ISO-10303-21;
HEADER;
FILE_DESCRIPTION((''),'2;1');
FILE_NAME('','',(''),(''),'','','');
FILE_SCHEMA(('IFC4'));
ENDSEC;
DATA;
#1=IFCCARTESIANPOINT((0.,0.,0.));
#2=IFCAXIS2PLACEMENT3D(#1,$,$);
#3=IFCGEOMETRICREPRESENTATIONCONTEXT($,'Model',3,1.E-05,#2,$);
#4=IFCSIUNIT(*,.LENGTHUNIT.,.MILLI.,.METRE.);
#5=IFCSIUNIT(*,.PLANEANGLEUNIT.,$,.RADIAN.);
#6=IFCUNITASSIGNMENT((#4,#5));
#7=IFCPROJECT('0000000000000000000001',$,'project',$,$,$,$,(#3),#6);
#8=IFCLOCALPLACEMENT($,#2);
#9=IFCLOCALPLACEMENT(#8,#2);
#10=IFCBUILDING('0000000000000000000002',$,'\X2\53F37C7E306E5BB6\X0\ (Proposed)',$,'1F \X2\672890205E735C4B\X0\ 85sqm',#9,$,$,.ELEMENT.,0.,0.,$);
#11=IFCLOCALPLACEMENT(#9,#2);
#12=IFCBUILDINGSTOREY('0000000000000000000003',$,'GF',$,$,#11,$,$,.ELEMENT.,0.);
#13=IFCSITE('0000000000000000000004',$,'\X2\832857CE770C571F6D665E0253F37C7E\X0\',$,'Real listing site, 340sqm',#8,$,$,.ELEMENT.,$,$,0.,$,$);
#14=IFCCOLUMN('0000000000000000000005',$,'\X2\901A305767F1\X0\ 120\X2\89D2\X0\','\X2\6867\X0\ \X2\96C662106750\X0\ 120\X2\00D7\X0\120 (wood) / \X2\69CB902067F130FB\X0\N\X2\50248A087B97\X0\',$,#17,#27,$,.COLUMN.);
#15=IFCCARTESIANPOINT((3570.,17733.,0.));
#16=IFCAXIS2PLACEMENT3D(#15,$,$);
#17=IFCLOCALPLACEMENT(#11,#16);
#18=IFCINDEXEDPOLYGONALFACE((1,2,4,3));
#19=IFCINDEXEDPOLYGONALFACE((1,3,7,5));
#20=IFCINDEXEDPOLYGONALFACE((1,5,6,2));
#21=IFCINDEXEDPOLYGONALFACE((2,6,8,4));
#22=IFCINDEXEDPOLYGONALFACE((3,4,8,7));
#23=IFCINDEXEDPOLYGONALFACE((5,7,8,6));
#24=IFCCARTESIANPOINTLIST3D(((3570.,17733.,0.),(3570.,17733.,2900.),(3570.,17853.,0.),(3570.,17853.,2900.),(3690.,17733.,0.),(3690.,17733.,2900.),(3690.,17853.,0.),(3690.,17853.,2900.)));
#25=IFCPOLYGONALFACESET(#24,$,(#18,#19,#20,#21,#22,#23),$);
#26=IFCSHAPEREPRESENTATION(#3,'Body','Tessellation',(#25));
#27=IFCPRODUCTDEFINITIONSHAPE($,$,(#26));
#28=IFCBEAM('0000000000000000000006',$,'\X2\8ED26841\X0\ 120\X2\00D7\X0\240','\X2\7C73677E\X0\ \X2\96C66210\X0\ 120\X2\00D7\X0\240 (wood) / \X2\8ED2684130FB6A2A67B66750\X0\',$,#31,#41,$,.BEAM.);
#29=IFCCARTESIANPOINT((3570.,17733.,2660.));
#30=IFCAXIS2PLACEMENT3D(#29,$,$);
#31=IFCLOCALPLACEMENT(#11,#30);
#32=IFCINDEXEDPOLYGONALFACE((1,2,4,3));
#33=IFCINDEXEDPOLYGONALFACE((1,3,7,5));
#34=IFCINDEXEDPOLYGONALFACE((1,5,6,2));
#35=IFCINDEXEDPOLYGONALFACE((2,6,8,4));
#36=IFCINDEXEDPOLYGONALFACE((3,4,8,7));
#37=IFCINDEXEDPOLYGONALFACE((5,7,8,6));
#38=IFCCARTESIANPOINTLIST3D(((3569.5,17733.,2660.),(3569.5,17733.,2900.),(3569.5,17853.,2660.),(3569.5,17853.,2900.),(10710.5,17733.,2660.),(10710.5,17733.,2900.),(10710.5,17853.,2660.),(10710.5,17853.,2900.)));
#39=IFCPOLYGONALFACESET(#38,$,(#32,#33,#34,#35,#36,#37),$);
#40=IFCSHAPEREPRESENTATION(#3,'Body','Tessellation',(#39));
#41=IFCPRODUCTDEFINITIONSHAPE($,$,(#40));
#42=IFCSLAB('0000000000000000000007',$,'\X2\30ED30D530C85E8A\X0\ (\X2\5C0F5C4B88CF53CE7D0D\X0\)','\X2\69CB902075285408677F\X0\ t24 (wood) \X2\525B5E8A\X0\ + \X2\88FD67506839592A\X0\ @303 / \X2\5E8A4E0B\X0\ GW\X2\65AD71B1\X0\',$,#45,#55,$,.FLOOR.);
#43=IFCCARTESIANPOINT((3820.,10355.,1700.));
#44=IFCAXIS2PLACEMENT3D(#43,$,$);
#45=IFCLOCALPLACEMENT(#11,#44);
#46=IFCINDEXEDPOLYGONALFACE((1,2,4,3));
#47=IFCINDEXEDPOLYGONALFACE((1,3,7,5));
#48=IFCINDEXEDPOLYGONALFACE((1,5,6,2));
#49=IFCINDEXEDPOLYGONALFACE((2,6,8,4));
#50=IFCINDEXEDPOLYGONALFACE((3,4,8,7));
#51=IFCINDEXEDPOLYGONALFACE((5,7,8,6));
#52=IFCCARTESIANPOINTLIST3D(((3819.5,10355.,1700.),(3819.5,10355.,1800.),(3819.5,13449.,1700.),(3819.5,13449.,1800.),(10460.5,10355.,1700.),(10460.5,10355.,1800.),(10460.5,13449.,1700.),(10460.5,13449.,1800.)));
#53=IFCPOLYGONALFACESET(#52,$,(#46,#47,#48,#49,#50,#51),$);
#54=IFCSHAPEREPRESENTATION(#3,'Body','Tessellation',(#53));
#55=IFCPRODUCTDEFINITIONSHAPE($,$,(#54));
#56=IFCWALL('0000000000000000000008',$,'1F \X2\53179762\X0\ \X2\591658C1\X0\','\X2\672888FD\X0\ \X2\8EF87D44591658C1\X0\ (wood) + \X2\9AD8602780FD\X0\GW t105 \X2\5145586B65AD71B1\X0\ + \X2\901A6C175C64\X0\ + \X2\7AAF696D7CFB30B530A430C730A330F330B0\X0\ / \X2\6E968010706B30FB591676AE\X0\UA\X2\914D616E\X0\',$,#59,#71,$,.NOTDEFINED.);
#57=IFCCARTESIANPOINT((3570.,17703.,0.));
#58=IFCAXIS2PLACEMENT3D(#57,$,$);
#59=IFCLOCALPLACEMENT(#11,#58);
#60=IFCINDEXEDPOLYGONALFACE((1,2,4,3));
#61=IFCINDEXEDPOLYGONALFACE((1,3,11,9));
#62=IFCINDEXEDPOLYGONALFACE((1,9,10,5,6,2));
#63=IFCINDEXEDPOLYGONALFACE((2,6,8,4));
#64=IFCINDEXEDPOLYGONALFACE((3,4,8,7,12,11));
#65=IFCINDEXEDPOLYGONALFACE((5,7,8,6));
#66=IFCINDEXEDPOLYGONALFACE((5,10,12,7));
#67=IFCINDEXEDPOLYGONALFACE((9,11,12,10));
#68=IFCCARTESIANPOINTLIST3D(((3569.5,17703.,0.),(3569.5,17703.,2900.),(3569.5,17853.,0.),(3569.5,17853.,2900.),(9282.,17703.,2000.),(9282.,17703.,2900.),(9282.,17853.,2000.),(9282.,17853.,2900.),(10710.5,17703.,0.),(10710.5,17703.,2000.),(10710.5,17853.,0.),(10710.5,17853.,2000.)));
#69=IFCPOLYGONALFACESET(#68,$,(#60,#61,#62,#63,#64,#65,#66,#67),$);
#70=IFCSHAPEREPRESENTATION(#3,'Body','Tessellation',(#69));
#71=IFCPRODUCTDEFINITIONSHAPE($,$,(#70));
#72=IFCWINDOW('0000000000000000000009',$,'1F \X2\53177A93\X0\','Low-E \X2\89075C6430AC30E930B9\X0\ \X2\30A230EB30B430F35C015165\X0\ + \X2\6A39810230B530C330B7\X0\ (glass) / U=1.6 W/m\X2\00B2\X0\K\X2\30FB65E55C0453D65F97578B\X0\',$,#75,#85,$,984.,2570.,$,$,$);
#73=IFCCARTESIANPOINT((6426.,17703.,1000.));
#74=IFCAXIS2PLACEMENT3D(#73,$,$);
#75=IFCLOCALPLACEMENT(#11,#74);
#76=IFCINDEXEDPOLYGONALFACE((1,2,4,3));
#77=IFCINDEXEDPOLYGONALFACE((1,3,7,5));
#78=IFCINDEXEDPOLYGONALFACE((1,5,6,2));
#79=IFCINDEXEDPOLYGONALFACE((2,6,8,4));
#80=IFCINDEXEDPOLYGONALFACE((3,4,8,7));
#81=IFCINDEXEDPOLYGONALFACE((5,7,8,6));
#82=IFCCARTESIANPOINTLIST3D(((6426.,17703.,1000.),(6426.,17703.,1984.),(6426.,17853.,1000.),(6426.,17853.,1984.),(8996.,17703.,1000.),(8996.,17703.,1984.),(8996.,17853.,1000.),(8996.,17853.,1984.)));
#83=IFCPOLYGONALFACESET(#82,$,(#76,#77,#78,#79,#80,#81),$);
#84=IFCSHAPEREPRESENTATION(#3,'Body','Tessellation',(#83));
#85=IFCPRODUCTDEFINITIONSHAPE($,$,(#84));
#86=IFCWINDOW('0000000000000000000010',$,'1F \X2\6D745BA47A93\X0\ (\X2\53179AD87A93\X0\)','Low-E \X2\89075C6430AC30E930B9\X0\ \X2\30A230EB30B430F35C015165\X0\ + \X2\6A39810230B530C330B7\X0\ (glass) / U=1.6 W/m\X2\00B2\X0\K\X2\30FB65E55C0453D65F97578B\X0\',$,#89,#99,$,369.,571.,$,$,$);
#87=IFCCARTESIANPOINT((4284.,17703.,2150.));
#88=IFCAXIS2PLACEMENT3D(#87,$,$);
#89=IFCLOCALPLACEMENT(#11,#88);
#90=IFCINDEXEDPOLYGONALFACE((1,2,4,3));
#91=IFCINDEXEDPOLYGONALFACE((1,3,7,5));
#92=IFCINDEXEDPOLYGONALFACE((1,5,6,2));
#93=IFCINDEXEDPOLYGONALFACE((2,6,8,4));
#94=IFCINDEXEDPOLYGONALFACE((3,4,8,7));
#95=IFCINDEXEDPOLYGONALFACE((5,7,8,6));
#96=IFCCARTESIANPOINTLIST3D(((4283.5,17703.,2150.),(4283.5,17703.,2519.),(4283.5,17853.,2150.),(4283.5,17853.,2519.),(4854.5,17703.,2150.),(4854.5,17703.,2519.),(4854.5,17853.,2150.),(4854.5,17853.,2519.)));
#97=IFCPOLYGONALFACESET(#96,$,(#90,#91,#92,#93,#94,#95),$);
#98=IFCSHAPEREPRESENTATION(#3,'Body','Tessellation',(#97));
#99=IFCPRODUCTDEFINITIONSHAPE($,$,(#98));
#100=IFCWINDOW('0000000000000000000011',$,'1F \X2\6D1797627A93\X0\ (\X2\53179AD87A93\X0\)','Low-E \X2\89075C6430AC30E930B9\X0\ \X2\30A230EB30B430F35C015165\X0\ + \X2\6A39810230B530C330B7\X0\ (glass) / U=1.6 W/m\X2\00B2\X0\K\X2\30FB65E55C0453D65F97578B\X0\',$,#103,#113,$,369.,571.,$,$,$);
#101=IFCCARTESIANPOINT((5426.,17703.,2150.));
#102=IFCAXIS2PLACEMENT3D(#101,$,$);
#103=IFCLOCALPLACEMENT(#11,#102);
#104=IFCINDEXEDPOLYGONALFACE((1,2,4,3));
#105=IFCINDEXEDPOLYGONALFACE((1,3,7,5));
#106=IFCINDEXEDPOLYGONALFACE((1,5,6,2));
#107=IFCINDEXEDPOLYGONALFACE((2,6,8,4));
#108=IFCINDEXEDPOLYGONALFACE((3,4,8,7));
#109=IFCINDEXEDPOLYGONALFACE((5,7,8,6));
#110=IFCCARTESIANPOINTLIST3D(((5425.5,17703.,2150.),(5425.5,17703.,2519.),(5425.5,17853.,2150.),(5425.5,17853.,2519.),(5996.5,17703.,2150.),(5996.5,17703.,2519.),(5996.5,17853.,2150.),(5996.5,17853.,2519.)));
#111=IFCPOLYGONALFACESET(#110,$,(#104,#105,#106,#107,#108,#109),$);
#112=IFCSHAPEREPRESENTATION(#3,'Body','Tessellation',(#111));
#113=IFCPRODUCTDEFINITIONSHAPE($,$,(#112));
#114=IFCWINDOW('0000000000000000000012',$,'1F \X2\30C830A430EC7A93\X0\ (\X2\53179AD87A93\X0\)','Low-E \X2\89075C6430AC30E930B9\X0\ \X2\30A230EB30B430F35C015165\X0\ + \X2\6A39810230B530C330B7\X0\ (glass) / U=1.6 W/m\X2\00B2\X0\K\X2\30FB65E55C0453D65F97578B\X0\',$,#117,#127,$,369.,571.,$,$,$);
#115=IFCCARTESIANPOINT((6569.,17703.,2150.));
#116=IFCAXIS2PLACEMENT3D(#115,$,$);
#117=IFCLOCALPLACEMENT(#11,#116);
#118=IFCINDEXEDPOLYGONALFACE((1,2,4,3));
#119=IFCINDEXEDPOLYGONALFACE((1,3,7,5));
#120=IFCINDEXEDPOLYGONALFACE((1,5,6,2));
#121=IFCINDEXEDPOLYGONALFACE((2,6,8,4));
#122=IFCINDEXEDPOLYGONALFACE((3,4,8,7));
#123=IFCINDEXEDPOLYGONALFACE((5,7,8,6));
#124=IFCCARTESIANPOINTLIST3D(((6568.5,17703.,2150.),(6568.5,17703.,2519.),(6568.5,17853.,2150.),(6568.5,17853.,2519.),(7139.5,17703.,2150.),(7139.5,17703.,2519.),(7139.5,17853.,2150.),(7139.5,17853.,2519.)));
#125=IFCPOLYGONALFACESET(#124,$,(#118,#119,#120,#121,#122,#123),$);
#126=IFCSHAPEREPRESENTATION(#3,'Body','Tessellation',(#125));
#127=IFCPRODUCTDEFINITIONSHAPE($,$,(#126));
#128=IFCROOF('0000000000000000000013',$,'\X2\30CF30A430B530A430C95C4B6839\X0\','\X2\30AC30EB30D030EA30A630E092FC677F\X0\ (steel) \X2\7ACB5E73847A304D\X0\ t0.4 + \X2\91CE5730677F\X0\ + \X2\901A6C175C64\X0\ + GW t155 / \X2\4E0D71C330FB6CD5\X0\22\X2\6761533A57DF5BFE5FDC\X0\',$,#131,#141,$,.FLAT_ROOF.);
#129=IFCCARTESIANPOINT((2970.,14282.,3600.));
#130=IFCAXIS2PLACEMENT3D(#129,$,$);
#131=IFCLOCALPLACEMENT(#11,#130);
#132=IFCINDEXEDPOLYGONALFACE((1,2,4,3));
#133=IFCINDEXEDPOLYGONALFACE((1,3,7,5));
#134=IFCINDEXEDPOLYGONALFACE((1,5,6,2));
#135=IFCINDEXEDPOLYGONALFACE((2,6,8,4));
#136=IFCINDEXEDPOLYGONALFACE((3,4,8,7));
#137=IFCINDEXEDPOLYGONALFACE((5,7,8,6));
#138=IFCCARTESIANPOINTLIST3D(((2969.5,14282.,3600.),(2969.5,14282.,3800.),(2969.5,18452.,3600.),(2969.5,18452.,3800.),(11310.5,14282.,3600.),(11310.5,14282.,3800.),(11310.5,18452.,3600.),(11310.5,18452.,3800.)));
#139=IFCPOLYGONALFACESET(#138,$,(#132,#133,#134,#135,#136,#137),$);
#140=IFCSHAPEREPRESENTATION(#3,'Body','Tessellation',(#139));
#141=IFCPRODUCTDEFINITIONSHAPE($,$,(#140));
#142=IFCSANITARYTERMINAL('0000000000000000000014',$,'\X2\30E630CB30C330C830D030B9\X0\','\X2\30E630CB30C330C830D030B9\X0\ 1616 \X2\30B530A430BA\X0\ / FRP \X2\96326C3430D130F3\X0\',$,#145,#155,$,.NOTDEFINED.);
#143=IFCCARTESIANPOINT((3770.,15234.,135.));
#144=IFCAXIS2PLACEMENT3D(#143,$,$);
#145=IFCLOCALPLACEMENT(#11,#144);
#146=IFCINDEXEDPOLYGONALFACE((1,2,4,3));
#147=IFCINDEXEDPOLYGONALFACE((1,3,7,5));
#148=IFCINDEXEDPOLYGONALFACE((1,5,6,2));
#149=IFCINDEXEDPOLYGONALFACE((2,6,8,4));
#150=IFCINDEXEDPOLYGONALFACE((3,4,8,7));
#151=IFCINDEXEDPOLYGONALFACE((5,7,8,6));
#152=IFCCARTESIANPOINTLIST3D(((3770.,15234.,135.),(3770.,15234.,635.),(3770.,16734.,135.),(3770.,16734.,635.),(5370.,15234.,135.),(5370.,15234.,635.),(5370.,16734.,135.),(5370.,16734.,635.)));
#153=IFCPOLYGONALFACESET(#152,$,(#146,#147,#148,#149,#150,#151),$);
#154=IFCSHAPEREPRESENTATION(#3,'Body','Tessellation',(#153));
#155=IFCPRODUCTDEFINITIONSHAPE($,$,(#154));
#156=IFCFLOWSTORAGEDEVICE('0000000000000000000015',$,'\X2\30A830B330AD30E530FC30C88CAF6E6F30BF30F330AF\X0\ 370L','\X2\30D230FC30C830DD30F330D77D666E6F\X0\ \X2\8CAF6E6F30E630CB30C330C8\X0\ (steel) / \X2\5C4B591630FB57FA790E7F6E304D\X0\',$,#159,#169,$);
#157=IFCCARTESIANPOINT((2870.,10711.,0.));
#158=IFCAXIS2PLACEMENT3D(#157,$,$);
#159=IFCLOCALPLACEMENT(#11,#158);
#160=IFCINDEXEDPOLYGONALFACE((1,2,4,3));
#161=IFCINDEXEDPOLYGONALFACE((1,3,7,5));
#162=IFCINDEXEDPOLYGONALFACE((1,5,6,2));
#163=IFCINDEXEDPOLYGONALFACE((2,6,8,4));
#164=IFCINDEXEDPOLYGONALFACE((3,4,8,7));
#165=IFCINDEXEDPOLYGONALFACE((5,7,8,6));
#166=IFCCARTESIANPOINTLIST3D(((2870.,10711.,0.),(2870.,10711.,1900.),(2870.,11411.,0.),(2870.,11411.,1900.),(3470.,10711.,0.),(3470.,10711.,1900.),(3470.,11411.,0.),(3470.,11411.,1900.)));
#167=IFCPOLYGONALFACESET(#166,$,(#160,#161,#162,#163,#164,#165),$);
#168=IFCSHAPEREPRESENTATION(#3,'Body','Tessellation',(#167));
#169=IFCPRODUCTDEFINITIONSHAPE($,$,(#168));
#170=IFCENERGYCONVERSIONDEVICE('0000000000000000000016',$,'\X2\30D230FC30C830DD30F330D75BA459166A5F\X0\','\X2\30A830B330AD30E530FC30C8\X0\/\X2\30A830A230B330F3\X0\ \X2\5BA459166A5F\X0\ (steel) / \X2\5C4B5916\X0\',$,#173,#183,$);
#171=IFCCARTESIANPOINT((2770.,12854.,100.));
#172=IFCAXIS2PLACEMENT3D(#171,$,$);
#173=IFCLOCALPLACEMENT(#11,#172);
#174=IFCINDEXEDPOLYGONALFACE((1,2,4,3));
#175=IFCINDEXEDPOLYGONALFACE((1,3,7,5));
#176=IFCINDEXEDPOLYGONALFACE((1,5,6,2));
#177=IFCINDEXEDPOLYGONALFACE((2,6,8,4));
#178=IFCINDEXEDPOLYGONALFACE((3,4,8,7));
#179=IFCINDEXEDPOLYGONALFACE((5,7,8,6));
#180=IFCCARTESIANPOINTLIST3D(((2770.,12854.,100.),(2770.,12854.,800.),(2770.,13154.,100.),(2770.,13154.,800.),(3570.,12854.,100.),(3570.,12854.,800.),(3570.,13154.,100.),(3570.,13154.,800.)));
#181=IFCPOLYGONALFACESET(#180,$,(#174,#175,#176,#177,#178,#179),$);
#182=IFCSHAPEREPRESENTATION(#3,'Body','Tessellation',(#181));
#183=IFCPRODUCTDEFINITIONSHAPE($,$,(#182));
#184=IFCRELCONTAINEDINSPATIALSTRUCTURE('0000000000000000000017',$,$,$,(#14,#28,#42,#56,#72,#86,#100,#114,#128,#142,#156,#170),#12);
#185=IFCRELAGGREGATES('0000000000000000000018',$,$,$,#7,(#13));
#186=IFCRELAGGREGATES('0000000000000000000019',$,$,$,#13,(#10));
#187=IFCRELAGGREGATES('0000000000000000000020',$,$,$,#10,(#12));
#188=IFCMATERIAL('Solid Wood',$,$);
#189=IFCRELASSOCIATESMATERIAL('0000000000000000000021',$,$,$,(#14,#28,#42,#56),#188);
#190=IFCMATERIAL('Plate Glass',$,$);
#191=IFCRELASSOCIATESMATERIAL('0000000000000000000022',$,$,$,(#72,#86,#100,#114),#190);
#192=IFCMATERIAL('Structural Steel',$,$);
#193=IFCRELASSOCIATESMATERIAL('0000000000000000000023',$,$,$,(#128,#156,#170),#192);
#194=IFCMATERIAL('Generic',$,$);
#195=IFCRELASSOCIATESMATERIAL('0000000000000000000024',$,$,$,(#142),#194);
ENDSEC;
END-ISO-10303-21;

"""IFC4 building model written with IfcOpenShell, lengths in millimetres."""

from ifc_helpers import new_model, si_unit, frame, frame_2d, origin, place, context, project, spatial, rectangle, extrude, material, element, fill, save


model = new_model("IFC4")

# Units and contexts
model_context = context("Model", 3, precision=1e-05, world=origin())
ifc_project = project(units=[si_unit("LENGTHUNIT", "METRE", prefix="MILLI"), si_unit("PLANEANGLEUNIT", "RADIAN")], contexts=[model_context])

# Site, building, storey
site_placement = place(None, origin())
site = spatial("IfcSite", under=ifc_project, at=site_placement, Name="茨城県土浦市右籾", ObjectType="Real listing site, 340sqm", CompositionType="ELEMENT", RefElevation=0.0)
building_placement = place(site_placement, origin())
building = spatial("IfcBuilding", under=site, at=building_placement, Name="右籾の家 (Proposed)", ObjectType="1F 木造平屋 85sqm", CompositionType="ELEMENT", ElevationOfRefHeight=0.0, ElevationOfTerrain=0.0)
storey_placement = place(building_placement, origin())
storey = spatial("IfcBuildingStorey", under=building, at=storey_placement, Name="GF", CompositionType="ELEMENT", Elevation=0.0)

# Column
ifc_material_1 = material(Name="Solid Wood")
column_1_placement = place(storey_placement, frame((3570.0, 17733.0, 0.0)))
element("IfcColumn", 1, at=column_1_placement, inside=storey, material=ifc_material_1, Name="通し柱 120角", Description="桧 集成材 120×120 (wood) / 構造柱・N値計算", PredefinedType="COLUMN", context=model_context, shape_type="SweptSolid", body=[
    extrude(rectangle(XDim=120.0, YDim=120.0, at=frame_2d((60.0, 60.0))), frame((3570.0, 17733.0, 0.0)), (0.0, 0.0, 1.0), 2900.0),
])

# Beam
beam_1_placement = place(storey_placement, frame((3570.0, 17733.0, 2660.0)))
element("IfcBeam", 2, at=beam_1_placement, inside=storey, material=ifc_material_1, Name="軒桁 120×240", Description="米松 集成 120×240 (wood) / 軒桁・横架材", PredefinedType="BEAM", context=model_context, shape_type="SweptSolid", body=[
    extrude(rectangle(XDim=7141.0, YDim=120.0, at=frame_2d((3570.0, 60.0))), frame((3570.0, 17733.0, 2660.0)), (0.0, 0.0, 1.0), 240.0),
])

# Slab
slab_placement = place(storey_placement, frame((3820.0, 10355.0, 1700.0)))
element("IfcSlab", 3, at=slab_placement, inside=storey, material=ifc_material_1, Name="ロフト床 (小屋裏収納)", Description="構造用合板 t24 (wood) 剛床 + 製材根太 @303 / 床下 GW断熱", PredefinedType="FLOOR", context=model_context, shape_type="SweptSolid", body=[
    extrude(rectangle(XDim=6641.0, YDim=3094.0, at=frame_2d((3320.0, 1547.0))), frame((3820.0, 10355.0, 1700.0)), (0.0, 0.0, 1.0), 100.0),
])

# Wall, openings, windows
wall_1_placement = place(storey_placement, frame((3570.0, 17703.0, 0.0)))
wall_1 = element("IfcWall", 4, at=wall_1_placement, inside=storey, material=ifc_material_1, Name="1F 北面 外壁", Description="木製 軸組外壁 (wood) + 高性能GW t105 充填断熱 + 通気層 + 窯業系サイディング / 準耐火・外皮UA配慮", PredefinedType="NOTDEFINED", context=model_context, shape_type="SweptSolid", body=[
    extrude(rectangle(XDim=7141.0, YDim=150.0, at=frame_2d((3570.0, 75.0))), frame((3570.0, 17703.0, 0.0)), (0.0, 0.0, 1.0), 2900.0),
])
opening_1_placement = place(storey_placement, frame((6426.0, 17703.0, 1000.0)))
opening_1 = element("IfcOpeningElement", 5, at=opening_1_placement, cuts=wall_1, PredefinedType="NOTDEFINED", context=model_context, shape_type="SweptSolid", body=[
    extrude(rectangle(XDim=2570.0, YDim=150.0, at=frame_2d((1285.0, 75.0))), frame((6426.0, 17703.0, 1000.0)), (0.0, 0.0, 1.0), 984.0),
])
opening_2_placement = place(storey_placement, frame((4284.0, 17703.0, 2150.0)))
opening_2 = element("IfcOpeningElement", 6, at=opening_2_placement, cuts=wall_1, PredefinedType="NOTDEFINED", context=model_context, shape_type="SweptSolid", body=[
    extrude(rectangle(XDim=571.0, YDim=150.0, at=frame_2d((285.0, 75.0))), frame((4284.0, 17703.0, 2150.0)), (0.0, 0.0, 1.0), 369.0),
])
opening_3_placement = place(storey_placement, frame((5426.0, 17703.0, 2150.0)))
opening_3 = element("IfcOpeningElement", 7, at=opening_3_placement, cuts=wall_1, PredefinedType="NOTDEFINED", context=model_context, shape_type="SweptSolid", body=[
    extrude(rectangle(XDim=571.0, YDim=150.0, at=frame_2d((285.0, 75.0))), frame((5426.0, 17703.0, 2150.0)), (0.0, 0.0, 1.0), 369.0),
])
opening_4_placement = place(storey_placement, frame((6569.0, 17703.0, 2150.0)))
opening_4 = element("IfcOpeningElement", 8, at=opening_4_placement, cuts=wall_1, PredefinedType="NOTDEFINED", context=model_context, shape_type="SweptSolid", body=[
    extrude(rectangle(XDim=571.0, YDim=150.0, at=frame_2d((285.0, 75.0))), frame((6569.0, 17703.0, 2150.0)), (0.0, 0.0, 1.0), 369.0),
])
ifc_material_2 = material(Name="Plate Glass")
window_1_placement = place(storey_placement, frame((6426.0, 17703.0, 1000.0)))
window_1 = element("IfcWindow", 9, at=window_1_placement, inside=storey, material=ifc_material_2, Name="1F 北窓", Description="Low-E 複層ガラス アルゴン封入 + 樹脂サッシ (glass) / U=1.6 W/m²K・日射取得型", OverallHeight=984.0, OverallWidth=2570.0, context=model_context, shape_type="SweptSolid", body=[
    extrude(rectangle(XDim=2570.0, YDim=150.0, at=frame_2d((1285.0, 75.0))), frame((6426.0, 17703.0, 1000.0)), (0.0, 0.0, 1.0), 984.0),
])
fill(opening_1, window_1)
window_2_placement = place(storey_placement, frame((4284.0, 17703.0, 2150.0)))
window_2 = element("IfcWindow", 10, at=window_2_placement, inside=storey, material=ifc_material_2, Name="1F 浴室窓 (北高窓)", Description="Low-E 複層ガラス アルゴン封入 + 樹脂サッシ (glass) / U=1.6 W/m²K・日射取得型", OverallHeight=369.0, OverallWidth=571.0, context=model_context, shape_type="SweptSolid", body=[
    extrude(rectangle(XDim=571.0, YDim=150.0, at=frame_2d((285.0, 75.0))), frame((4284.0, 17703.0, 2150.0)), (0.0, 0.0, 1.0), 369.0),
])
fill(opening_2, window_2)
window_3_placement = place(storey_placement, frame((5426.0, 17703.0, 2150.0)))
window_3 = element("IfcWindow", 11, at=window_3_placement, inside=storey, material=ifc_material_2, Name="1F 洗面窓 (北高窓)", Description="Low-E 複層ガラス アルゴン封入 + 樹脂サッシ (glass) / U=1.6 W/m²K・日射取得型", OverallHeight=369.0, OverallWidth=571.0, context=model_context, shape_type="SweptSolid", body=[
    extrude(rectangle(XDim=571.0, YDim=150.0, at=frame_2d((285.0, 75.0))), frame((5426.0, 17703.0, 2150.0)), (0.0, 0.0, 1.0), 369.0),
])
fill(opening_3, window_3)
window_4_placement = place(storey_placement, frame((6569.0, 17703.0, 2150.0)))
window_4 = element("IfcWindow", 12, at=window_4_placement, inside=storey, material=ifc_material_2, Name="1F トイレ窓 (北高窓)", Description="Low-E 複層ガラス アルゴン封入 + 樹脂サッシ (glass) / U=1.6 W/m²K・日射取得型", OverallHeight=369.0, OverallWidth=571.0, context=model_context, shape_type="SweptSolid", body=[
    extrude(rectangle(XDim=571.0, YDim=150.0, at=frame_2d((285.0, 75.0))), frame((6569.0, 17703.0, 2150.0)), (0.0, 0.0, 1.0), 369.0),
])
fill(opening_4, window_4)

# Roof
ifc_material_3 = material(Name="Structural Steel")
roof_placement = place(storey_placement, frame((2970.0, 14282.0, 3600.0)))
element("IfcRoof", 13, at=roof_placement, inside=storey, material=ifc_material_3, Name="ハイサイド屋根", Description="ガルバリウム鋼板 (steel) 立平葺き t0.4 + 野地板 + 通気層 + GW t155 / 不燃・法22条区域対応", PredefinedType="FLAT_ROOF", context=model_context, shape_type="SweptSolid", body=[
    extrude(rectangle(XDim=8341.0, YDim=4170.0, at=frame_2d((4170.0, 2085.0))), frame((2970.0, 14282.0, 3600.0)), (0.0, 0.0, 1.0), 200.0),
])

# Sanitary terminal
ifc_material_4 = material(Name="Generic")
sanitary_terminal_placement = place(storey_placement, frame((3770.0, 15234.0, 135.0)))
element("IfcSanitaryTerminal", 14, at=sanitary_terminal_placement, inside=storey, material=ifc_material_4, Name="ユニットバス", Description="ユニットバス 1616 サイズ / FRP 防水パン", PredefinedType="NOTDEFINED", context=model_context, shape_type="SweptSolid", body=[
    extrude(rectangle(XDim=1600.0, YDim=1500.0, at=frame_2d((800.0, 750.0))), frame((3770.0, 15234.0, 135.0)), (0.0, 0.0, 1.0), 500.0),
])

# Flow storage device
flow_storage_device_placement = place(storey_placement, frame((2870.0, 10711.0, 0.0)))
element("IfcFlowStorageDevice", 15, at=flow_storage_device_placement, inside=storey, material=ifc_material_3, Name="エコキュート貯湯タンク 370L", Description="ヒートポンプ給湯 貯湯ユニット (steel) / 屋外・基礎置き", context=model_context, shape_type="SweptSolid", body=[
    extrude(rectangle(XDim=600.0, YDim=700.0, at=frame_2d((300.0, 350.0))), frame((2870.0, 10711.0, 0.0)), (0.0, 0.0, 1.0), 1900.0),
])

# Energy conversion device
energy_conversion_device_placement = place(storey_placement, frame((2770.0, 12854.0, 100.0)))
element("IfcEnergyConversionDevice", 16, at=energy_conversion_device_placement, inside=storey, material=ifc_material_3, Name="ヒートポンプ室外機", Description="エコキュート/エアコン 室外機 (steel) / 屋外", context=model_context, shape_type="SweptSolid", body=[
    extrude(rectangle(XDim=800.0, YDim=300.0, at=frame_2d((400.0, 150.0))), frame((2770.0, 12854.0, 100.0)), (0.0, 0.0, 1.0), 700.0),
])

save(model, "model.ifc")
